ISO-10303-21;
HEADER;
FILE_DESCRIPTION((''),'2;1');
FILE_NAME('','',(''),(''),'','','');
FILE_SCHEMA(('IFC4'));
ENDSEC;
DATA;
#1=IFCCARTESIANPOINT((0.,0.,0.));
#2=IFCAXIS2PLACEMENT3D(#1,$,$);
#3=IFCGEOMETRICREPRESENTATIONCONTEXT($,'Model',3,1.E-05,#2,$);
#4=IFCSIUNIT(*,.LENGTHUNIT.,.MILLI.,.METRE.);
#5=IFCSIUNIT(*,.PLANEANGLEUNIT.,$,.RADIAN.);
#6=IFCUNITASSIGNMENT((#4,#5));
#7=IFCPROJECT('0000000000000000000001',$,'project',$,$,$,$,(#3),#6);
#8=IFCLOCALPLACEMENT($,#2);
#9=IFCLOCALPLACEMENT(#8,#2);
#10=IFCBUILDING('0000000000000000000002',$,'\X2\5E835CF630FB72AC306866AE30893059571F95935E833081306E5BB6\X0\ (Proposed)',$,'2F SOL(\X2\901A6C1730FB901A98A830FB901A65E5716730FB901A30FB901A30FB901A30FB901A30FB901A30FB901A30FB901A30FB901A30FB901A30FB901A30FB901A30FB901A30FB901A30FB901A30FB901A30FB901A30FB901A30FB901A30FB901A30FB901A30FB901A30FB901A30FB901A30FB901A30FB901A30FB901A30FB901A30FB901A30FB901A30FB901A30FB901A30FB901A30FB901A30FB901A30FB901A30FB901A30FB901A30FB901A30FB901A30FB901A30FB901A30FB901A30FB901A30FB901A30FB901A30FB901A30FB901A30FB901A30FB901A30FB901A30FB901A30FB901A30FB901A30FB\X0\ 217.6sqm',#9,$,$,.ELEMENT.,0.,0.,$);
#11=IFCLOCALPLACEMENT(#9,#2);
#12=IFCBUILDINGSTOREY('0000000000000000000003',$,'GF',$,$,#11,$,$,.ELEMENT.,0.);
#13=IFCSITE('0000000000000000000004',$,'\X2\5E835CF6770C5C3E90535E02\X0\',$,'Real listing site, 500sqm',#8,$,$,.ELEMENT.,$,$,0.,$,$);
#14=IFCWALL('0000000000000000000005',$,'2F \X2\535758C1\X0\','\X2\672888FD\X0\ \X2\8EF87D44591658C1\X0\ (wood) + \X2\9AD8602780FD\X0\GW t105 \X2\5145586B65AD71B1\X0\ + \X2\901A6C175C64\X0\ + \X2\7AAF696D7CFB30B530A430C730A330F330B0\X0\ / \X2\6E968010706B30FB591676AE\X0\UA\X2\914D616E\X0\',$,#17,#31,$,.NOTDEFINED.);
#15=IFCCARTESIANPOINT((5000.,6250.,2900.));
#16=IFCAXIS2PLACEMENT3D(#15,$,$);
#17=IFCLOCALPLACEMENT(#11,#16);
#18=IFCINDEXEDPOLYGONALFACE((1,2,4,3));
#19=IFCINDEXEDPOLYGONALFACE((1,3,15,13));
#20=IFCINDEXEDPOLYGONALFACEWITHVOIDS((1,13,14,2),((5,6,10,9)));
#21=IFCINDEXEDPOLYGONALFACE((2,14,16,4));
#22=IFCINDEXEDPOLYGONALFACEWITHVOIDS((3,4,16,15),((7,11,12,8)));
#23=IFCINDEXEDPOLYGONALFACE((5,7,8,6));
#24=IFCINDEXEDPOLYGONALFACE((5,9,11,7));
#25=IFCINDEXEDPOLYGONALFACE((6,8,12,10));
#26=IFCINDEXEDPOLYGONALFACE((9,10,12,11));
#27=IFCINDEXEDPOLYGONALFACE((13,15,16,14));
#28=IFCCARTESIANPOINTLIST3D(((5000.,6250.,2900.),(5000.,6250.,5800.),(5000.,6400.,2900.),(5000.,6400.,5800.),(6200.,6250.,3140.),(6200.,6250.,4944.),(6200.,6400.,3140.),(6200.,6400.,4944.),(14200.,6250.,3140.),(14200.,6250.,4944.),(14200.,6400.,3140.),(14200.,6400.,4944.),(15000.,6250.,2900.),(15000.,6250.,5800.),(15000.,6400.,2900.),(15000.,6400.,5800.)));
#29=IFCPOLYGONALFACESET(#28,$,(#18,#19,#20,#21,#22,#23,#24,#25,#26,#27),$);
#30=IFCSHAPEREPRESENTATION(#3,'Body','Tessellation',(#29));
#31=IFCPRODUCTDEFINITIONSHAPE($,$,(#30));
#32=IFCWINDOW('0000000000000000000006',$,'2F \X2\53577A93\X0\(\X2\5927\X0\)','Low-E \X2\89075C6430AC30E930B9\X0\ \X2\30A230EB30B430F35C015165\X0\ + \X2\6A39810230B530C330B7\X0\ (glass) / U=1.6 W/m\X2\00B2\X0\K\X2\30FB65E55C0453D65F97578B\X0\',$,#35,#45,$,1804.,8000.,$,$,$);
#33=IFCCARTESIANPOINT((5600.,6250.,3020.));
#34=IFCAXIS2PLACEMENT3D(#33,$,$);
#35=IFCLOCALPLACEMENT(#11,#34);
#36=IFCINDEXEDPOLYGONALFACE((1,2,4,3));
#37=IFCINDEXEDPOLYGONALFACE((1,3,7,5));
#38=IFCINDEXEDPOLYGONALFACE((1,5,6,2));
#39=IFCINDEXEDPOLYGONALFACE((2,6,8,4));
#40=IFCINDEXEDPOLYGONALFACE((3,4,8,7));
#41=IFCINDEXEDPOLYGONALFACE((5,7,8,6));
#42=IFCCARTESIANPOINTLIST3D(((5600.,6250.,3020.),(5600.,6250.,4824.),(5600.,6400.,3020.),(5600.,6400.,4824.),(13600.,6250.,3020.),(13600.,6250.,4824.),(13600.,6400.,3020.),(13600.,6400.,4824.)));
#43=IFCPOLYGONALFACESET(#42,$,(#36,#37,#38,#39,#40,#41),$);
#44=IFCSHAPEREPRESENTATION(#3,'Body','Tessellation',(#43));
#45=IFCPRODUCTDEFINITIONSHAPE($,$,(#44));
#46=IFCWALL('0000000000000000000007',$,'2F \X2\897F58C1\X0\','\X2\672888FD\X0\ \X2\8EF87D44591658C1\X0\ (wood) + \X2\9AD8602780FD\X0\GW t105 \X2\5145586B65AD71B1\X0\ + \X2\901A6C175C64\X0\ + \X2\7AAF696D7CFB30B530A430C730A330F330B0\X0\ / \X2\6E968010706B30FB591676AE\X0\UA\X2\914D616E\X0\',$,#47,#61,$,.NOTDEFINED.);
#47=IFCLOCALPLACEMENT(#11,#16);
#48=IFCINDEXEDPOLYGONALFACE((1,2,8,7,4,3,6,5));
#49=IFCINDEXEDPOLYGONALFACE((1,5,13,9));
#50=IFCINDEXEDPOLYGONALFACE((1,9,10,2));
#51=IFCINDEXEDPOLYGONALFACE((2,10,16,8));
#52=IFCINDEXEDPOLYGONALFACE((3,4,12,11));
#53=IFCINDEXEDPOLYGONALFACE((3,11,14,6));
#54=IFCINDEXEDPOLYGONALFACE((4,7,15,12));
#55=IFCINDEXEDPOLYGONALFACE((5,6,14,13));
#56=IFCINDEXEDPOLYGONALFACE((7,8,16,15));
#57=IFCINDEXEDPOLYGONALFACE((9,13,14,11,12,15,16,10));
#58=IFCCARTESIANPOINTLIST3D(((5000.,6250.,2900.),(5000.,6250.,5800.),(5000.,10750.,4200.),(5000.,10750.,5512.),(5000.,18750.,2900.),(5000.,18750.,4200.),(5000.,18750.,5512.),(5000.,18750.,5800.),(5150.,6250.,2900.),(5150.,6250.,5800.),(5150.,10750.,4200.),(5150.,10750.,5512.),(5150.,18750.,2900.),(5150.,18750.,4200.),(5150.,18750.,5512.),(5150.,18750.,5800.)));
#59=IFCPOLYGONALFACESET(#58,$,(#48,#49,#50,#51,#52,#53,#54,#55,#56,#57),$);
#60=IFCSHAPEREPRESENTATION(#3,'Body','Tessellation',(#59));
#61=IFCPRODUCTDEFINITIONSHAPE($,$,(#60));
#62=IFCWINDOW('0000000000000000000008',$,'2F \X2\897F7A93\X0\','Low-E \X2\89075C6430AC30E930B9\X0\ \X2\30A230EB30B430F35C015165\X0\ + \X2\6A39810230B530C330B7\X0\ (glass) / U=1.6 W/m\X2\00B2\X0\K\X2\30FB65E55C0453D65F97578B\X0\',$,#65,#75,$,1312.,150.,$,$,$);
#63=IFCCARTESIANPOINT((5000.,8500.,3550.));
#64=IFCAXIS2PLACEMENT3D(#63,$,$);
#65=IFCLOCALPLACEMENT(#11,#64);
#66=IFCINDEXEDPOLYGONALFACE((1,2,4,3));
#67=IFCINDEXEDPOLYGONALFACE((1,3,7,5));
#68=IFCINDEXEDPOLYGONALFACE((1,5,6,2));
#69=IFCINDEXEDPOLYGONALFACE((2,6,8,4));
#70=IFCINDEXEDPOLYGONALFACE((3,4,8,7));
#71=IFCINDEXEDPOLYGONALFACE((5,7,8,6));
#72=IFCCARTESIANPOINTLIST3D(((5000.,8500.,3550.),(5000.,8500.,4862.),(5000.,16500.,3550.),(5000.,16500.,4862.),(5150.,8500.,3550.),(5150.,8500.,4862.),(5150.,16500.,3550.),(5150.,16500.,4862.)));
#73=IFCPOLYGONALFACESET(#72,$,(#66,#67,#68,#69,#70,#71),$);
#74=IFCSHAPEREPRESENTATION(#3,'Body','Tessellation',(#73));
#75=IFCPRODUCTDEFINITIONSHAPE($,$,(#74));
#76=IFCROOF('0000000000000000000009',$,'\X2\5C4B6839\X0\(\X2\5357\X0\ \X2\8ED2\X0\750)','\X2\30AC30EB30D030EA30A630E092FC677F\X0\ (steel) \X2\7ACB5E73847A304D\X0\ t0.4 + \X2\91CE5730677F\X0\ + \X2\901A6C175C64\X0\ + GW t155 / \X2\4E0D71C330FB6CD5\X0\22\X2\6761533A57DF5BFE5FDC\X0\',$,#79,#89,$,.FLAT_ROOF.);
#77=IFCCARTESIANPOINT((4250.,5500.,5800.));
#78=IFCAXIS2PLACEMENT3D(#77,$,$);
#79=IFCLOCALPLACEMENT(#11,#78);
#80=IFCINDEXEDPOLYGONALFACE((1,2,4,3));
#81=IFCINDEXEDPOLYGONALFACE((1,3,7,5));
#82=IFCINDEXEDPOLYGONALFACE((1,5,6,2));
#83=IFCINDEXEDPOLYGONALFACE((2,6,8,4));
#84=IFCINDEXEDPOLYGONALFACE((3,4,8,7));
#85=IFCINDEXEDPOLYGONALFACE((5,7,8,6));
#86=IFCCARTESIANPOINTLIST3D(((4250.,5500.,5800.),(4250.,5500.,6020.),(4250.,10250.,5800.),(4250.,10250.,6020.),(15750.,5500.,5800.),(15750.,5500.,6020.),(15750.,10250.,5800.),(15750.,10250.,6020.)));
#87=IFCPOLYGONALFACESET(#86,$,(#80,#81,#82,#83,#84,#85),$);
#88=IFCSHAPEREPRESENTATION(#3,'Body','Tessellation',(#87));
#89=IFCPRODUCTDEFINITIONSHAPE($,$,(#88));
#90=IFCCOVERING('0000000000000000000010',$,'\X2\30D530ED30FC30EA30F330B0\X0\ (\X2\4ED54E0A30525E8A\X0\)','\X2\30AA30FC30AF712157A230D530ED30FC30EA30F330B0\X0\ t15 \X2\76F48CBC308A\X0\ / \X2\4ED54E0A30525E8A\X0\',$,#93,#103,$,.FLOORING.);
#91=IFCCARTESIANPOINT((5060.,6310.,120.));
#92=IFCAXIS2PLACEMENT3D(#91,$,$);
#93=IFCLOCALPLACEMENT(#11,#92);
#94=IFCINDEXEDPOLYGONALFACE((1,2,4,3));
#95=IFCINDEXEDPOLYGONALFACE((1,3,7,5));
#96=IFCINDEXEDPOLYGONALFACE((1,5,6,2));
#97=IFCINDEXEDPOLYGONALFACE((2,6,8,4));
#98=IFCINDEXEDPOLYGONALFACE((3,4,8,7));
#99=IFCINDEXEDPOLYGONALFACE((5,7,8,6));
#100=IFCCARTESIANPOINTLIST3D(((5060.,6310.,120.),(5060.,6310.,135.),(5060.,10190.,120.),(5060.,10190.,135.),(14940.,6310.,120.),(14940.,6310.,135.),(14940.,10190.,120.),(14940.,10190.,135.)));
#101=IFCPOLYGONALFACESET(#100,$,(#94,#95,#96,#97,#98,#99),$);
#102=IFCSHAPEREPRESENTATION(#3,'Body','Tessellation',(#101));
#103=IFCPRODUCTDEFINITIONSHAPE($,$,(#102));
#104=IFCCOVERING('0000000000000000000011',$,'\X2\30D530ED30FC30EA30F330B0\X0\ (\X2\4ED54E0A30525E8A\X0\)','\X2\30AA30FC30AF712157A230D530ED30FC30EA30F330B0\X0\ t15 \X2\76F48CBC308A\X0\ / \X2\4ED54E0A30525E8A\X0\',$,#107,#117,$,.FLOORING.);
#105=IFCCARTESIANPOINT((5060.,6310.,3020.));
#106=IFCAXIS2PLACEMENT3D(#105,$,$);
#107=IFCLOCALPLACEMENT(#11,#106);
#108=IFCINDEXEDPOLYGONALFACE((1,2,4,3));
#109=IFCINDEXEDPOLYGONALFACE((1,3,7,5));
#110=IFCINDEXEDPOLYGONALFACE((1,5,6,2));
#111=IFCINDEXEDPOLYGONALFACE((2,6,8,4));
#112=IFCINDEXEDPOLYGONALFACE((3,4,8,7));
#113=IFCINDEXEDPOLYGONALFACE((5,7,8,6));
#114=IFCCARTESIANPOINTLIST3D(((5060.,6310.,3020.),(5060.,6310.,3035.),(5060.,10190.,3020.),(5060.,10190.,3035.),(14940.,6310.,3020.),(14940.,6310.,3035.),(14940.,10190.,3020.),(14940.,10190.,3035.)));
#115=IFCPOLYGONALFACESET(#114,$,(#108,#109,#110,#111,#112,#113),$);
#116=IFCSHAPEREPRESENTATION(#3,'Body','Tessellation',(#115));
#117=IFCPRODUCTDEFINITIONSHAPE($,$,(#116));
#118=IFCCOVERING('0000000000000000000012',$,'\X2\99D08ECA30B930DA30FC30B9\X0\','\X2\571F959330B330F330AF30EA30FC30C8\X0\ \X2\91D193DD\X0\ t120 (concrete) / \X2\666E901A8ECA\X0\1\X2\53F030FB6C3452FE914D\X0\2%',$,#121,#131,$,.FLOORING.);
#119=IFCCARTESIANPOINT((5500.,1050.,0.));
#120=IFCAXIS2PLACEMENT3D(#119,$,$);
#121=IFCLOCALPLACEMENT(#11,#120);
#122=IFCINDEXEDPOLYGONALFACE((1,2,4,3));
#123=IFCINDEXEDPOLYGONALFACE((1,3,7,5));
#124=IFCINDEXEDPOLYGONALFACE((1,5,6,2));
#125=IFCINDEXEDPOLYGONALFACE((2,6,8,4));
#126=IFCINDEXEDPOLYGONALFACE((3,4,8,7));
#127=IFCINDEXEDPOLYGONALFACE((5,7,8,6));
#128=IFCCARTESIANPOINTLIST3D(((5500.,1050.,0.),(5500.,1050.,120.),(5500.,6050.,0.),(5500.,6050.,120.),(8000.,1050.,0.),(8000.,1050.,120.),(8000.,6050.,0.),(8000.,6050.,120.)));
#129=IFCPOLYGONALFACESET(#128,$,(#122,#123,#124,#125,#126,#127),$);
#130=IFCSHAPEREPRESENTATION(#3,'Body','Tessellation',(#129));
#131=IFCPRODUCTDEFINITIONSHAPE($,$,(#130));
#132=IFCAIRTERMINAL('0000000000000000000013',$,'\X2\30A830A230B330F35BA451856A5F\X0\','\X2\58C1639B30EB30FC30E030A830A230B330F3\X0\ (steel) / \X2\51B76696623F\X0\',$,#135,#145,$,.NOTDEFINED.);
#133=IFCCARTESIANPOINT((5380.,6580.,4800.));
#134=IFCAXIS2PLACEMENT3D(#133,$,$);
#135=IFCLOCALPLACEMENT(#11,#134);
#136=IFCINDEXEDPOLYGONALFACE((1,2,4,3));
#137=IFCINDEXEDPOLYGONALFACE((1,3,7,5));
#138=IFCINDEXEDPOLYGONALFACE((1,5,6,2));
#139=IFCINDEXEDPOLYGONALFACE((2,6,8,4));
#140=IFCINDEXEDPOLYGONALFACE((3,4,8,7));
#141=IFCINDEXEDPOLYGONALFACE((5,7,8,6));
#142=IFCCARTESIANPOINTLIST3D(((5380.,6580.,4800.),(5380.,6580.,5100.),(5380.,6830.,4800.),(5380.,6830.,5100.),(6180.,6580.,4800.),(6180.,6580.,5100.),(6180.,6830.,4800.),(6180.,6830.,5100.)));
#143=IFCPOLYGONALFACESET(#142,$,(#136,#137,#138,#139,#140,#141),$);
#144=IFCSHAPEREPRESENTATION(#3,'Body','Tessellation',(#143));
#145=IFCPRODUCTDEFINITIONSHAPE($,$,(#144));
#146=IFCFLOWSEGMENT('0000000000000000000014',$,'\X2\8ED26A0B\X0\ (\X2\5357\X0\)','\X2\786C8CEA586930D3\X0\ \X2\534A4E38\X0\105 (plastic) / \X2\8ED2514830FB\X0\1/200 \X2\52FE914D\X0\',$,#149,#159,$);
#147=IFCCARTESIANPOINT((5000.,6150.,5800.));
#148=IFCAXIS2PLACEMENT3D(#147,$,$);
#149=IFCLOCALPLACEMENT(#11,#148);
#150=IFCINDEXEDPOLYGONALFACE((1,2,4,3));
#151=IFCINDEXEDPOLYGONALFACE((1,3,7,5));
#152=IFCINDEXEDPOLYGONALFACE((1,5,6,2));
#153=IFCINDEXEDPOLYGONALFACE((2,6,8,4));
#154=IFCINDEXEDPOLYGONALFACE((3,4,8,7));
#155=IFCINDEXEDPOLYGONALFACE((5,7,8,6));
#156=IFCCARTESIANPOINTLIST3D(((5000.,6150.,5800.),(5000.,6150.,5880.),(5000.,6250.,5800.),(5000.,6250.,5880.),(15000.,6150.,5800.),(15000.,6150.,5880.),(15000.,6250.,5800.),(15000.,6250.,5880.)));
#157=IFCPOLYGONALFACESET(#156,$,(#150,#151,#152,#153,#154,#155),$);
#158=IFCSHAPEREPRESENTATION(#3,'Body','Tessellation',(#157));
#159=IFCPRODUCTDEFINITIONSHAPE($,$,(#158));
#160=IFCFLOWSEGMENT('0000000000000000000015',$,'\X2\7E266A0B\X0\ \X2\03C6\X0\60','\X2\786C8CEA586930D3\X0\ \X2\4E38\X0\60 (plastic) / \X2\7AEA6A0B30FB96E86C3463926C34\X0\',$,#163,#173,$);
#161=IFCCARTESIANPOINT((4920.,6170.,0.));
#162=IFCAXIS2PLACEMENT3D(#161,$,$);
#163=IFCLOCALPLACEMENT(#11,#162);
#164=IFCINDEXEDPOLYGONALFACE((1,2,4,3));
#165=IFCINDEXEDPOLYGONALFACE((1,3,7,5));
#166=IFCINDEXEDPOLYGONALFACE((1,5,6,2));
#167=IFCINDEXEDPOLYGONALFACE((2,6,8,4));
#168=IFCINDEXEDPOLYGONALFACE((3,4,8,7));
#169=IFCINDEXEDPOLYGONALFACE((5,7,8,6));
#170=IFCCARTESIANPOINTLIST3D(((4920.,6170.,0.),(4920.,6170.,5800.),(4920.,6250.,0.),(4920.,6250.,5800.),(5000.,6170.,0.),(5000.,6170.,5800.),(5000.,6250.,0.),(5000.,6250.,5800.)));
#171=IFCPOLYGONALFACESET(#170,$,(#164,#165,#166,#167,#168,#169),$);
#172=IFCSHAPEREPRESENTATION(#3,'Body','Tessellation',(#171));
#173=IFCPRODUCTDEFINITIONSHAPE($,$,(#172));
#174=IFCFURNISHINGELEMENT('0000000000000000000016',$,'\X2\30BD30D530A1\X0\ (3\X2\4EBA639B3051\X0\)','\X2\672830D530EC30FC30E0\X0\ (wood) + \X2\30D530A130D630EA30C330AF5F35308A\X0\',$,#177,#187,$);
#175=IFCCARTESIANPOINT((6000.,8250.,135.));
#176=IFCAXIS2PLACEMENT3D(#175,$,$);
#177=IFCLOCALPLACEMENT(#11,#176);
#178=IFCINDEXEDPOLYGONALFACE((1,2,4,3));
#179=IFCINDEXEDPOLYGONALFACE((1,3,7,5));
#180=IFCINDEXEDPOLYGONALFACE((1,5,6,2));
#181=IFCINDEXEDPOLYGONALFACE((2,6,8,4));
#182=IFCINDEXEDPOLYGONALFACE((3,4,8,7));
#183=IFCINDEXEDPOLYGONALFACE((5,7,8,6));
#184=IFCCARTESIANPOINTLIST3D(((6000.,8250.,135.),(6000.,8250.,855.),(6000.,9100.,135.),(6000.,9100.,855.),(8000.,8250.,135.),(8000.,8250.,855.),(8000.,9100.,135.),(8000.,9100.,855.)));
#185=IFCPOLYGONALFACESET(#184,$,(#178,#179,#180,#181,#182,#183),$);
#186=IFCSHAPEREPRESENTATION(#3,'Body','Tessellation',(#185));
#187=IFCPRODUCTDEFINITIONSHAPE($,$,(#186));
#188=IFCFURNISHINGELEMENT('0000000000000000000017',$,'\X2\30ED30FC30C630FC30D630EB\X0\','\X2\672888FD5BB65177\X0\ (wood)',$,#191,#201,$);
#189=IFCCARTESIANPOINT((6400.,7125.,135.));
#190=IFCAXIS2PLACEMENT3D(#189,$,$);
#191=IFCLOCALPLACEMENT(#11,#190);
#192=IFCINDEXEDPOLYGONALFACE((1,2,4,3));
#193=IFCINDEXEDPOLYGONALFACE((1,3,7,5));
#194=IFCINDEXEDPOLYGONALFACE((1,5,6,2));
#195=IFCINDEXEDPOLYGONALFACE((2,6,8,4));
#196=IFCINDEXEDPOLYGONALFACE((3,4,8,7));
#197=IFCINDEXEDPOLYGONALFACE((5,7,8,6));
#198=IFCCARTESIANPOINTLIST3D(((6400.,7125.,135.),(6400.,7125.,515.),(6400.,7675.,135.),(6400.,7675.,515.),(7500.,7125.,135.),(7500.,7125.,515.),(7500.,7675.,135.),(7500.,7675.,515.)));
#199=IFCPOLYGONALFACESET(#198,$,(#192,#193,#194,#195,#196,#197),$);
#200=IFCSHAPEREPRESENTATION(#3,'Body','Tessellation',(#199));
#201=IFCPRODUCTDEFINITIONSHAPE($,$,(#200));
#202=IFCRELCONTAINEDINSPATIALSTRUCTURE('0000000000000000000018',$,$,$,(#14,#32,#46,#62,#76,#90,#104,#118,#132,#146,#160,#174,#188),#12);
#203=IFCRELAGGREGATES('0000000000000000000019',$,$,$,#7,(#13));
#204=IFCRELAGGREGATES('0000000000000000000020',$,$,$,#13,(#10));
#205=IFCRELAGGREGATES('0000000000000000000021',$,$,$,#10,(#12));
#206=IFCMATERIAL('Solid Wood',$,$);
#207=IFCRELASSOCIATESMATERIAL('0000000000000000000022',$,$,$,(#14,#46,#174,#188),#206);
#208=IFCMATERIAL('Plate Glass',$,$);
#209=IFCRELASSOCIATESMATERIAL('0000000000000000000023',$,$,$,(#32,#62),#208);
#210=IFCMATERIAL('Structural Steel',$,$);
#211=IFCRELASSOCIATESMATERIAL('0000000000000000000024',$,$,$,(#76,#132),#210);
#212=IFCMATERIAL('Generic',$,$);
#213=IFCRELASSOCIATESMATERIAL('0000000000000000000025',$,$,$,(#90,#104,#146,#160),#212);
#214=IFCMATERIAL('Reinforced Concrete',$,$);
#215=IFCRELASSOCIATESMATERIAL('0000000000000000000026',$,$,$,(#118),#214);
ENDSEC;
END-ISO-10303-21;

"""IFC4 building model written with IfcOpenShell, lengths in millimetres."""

from ifc_helpers import new_model, si_unit, frame, frame_2d, origin, place, context, project, spatial, rectangle, extrude, material, element, fill, save


model = new_model("IFC4")

# Units and contexts
model_context = context("Model", 3, precision=1e-05, world=origin())
ifc_project = project(units=[si_unit("LENGTHUNIT", "METRE", prefix="MILLI"), si_unit("PLANEANGLEUNIT", "RADIAN")], contexts=[model_context])

# Site, building, storey
site_placement = place(None, origin())
site = spatial("IfcSite", under=ifc_project, at=site_placement, Name="広島県尾道市", ObjectType="Real listing site, 500sqm", CompositionType="ELEMENT", RefElevation=0.0)
building_placement = place(site_placement, origin())
building = spatial("IfcBuilding", under=site, at=building_placement, Name="広島・犬と暮らす土間広めの家 (Proposed)", ObjectType="2F SOL(通気・通風・通日照・通・通・通・通・通・通・通・通・通・通・通・通・通・通・通・通・通・通・通・通・通・通・通・通・通・通・通・通・通・通・通・通・通・通・通・通・通・通・通・通・通・通・通・通・通・通・通・通・通・通・通・通・通・ 217.6sqm", CompositionType="ELEMENT", ElevationOfRefHeight=0.0, ElevationOfTerrain=0.0)
storey_placement = place(building_placement, origin())
storey = spatial("IfcBuildingStorey", under=building, at=storey_placement, Name="GF", CompositionType="ELEMENT", Elevation=0.0)

# Shared definitions
ifc_material_1 = material(Name="Solid Wood")

# Shared definitions
ifc_material_2 = material(Name="Reinforced Concrete")

# Shared definitions
ifc_material_3 = material(Name="Plate Glass")

# Walls, openings, windows
wall_1_placement = place(storey_placement, frame((5000.0, 6250.0, 2900.0)))
wall_1 = element("IfcWall", 1, at=wall_1_placement, inside=storey, material=ifc_material_1, Name="2F 南壁", Description="木製 軸組外壁 (wood) + 高性能GW t105 充填断熱 + 通気層 + 窯業系サイディング / 準耐火・外皮UA配慮", PredefinedType="NOTDEFINED", context=model_context, shape_type="SweptSolid", body=[
    extrude(rectangle(XDim=10000.0, YDim=150.0, at=frame_2d((5000.0, 75.0))), frame((5000.0, 6250.0, 2900.0)), (0.0, 0.0, 1.0), 2900.0),
])
opening_1_placement = place(storey_placement, frame((5600.0, 6250.0, 3020.0)))
opening_1 = element("IfcOpeningElement", 2, at=opening_1_placement, cuts=wall_1, PredefinedType="NOTDEFINED", context=model_context, shape_type="SweptSolid", body=[
    extrude(rectangle(XDim=8000.0, YDim=150.0, at=frame_2d((4000.0, 75.0))), frame((5600.0, 6250.0, 3020.0)), (0.0, 0.0, 1.0), 1804.0),
])
window_1_placement = place(storey_placement, frame((5600.0, 6250.0, 3020.0)))
window_1 = element("IfcWindow", 3, at=window_1_placement, inside=storey, material=ifc_material_3, Name="2F 南窓(大)", Description="Low-E 複層ガラス アルゴン封入 + 樹脂サッシ (glass) / U=1.6 W/m²K・日射取得型", OverallHeight=1804.0, OverallWidth=8000.0, context=model_context, shape_type="SweptSolid", body=[
    extrude(rectangle(XDim=8000.0, YDim=150.0, at=frame_2d((4000.0, 75.0))), frame((5600.0, 6250.0, 3020.0)), (0.0, 0.0, 1.0), 1804.0),
])
fill(opening_1, window_1)
wall_2_placement = place(storey_placement, frame((5000.0, 6250.0, 2900.0)))
wall_2 = element("IfcWall", 4, at=wall_2_placement, inside=storey, material=ifc_material_1, Name="2F 西壁", Description="木製 軸組外壁 (wood) + 高性能GW t105 充填断熱 + 通気層 + 窯業系サイディング / 準耐火・外皮UA配慮", PredefinedType="NOTDEFINED", context=model_context, shape_type="SweptSolid", body=[
    extrude(rectangle(XDim=150.0, YDim=12500.0, at=frame_2d((75.0, 6250.0))), frame((5000.0, 6250.0, 2900.0)), (0.0, 0.0, 1.0), 2900.0),
])
opening_2_placement = place(storey_placement, frame((5000.0, 8500.0, 3550.0)))
opening_2 = element("IfcOpeningElement", 5, at=opening_2_placement, cuts=wall_2, PredefinedType="NOTDEFINED", context=model_context, shape_type="SweptSolid", body=[
    extrude(rectangle(XDim=150.0, YDim=8000.0, at=frame_2d((75.0, 4000.0))), frame((5000.0, 8500.0, 3550.0)), (0.0, 0.0, 1.0), 1312.0),
])
window_2_placement = place(storey_placement, frame((5000.0, 8500.0, 3550.0)))
window_2 = element("IfcWindow", 6, at=window_2_placement, inside=storey, material=ifc_material_3, Name="2F 西窓", Description="Low-E 複層ガラス アルゴン封入 + 樹脂サッシ (glass) / U=1.6 W/m²K・日射取得型", OverallHeight=1312.0, OverallWidth=150.0, context=model_context, shape_type="SweptSolid", body=[
    extrude(rectangle(XDim=150.0, YDim=8000.0, at=frame_2d((75.0, 4000.0))), frame((5000.0, 8500.0, 3550.0)), (0.0, 0.0, 1.0), 1312.0),
])
fill(opening_2, window_2)

# Roof
ifc_material_4 = material(Name="Structural Steel")
for number, where, name in (
    (7, (4250.0, 5500.0, 5800.0), "屋根(南 軒750)"),
):
    element("IfcRoof", number, at=place(storey_placement, frame(where)), inside=storey, material=ifc_material_4, Name=name, Description="ガルバリウム鋼板 (steel) 立平葺き t0.4 + 野地板 + 通気層 + GW t155 / 不燃・法22条区域対応", PredefinedType="FLAT_ROOF", context=model_context, shape_type="SweptSolid", body=[
        extrude(rectangle(XDim=11500.0, YDim=4750.0, at=frame_2d((5750.0, 2375.0))), frame((4250.0, 5500.0, 5800.0)), (0.0, 0.0, 1.0), 220.0),
    ])

# Coverings
ifc_material_5 = material(Name="Generic")
covering_1_placement = place(storey_placement, frame((5060.0, 6310.0, 120.0)))
element("IfcCovering", 8, at=covering_1_placement, inside=storey, material=ifc_material_5, Name="フローリング (仕上げ床)", Description="オーク無垢フローリング t15 直貼り / 仕上げ床", PredefinedType="FLOORING", context=model_context, shape_type="SweptSolid", body=[
    extrude(rectangle(XDim=9880.0, YDim=3880.0, at=frame_2d((4940.0, 1940.0))), frame((5060.0, 6310.0, 120.0)), (0.0, 0.0, 1.0), 15.0),
])
covering_2_placement = place(storey_placement, frame((5060.0, 6310.0, 3020.0)))
element("IfcCovering", 9, at=covering_2_placement, inside=storey, material=ifc_material_5, Name="フローリング (仕上げ床)", Description="オーク無垢フローリング t15 直貼り / 仕上げ床", PredefinedType="FLOORING", context=model_context, shape_type="SweptSolid", body=[
    extrude(rectangle(XDim=9880.0, YDim=3880.0, at=frame_2d((4940.0, 1940.0))), frame((5060.0, 6310.0, 3020.0)), (0.0, 0.0, 1.0), 15.0),
])
covering_3_placement = place(storey_placement, frame((5500.0, 1050.0, 0.0)))
element("IfcCovering", 10, at=covering_3_placement, inside=storey, material=ifc_material_2, Name="駐車スペース", Description="土間コンクリート 金鏝 t120 (concrete) / 普通車1台・水勾配2%", PredefinedType="FLOORING", context=model_context, shape_type="SweptSolid", body=[
    extrude(rectangle(XDim=2500.0, YDim=5000.0, at=frame_2d((1250.0, 2500.0))), frame((5500.0, 1050.0, 0.0)), (0.0, 0.0, 1.0), 120.0),
])

# Air terminal
air_terminal_placement = place(storey_placement, frame((5380.0, 6580.0, 4800.0)))
element("IfcAirTerminal", 11, at=air_terminal_placement, inside=storey, material=ifc_material_4, Name="エアコン室内機", Description="壁掛ルームエアコン (steel) / 冷暖房", PredefinedType="NOTDEFINED", context=model_context, shape_type="SweptSolid", body=[
    extrude(rectangle(XDim=800.0, YDim=250.0, at=frame_2d((400.0, 125.0))), frame((5380.0, 6580.0, 4800.0)), (0.0, 0.0, 1.0), 300.0),
])

# Flow segments
flow_segment_1_placement = place(storey_placement, frame((5000.0, 6150.0, 5800.0)))
element("IfcFlowSegment", 12, at=flow_segment_1_placement, inside=storey, material=ifc_material_5, Name="軒樋 (南)", Description="硬質塩ビ 半丸105 (plastic) / 軒先・1/200 勾配", context=model_context, shape_type="SweptSolid", body=[
    extrude(rectangle(XDim=10000.0, YDim=100.0, at=frame_2d((5000.0, 50.0))), frame((5000.0, 6150.0, 5800.0)), (0.0, 0.0, 1.0), 80.0),
])
flow_segment_2_placement = place(storey_placement, frame((4920.0, 6170.0, 0.0)))
element("IfcFlowSegment", 13, at=flow_segment_2_placement, inside=storey, material=ifc_material_5, Name="縦樋 φ60", Description="硬質塩ビ 丸60 (plastic) / 竪樋・雨水排水", context=model_context, shape_type="SweptSolid", body=[
    extrude(rectangle(XDim=80.0, YDim=80.0, at=frame_2d((40.0, 40.0))), frame((4920.0, 6170.0, 0.0)), (0.0, 0.0, 1.0), 5800.0),
])

# Furnishing elements
furnishing_1_placement = place(storey_placement, frame((6000.0, 8250.0, 135.0)))
element("IfcFurnishingElement", 14, at=furnishing_1_placement, inside=storey, material=ifc_material_1, Name="ソファ (3人掛け)", Description="木フレーム (wood) + ファブリック張り", context=model_context, shape_type="SweptSolid", body=[
    extrude(rectangle(XDim=2000.0, YDim=850.0, at=frame_2d((1000.0, 425.0))), frame((6000.0, 8250.0, 135.0)), (0.0, 0.0, 1.0), 720.0),
])
furnishing_2_placement = place(storey_placement, frame((6400.0, 7125.0, 135.0)))
element("IfcFurnishingElement", 15, at=furnishing_2_placement, inside=storey, material=ifc_material_1, Name="ローテーブル", Description="木製家具 (wood)", context=model_context, shape_type="SweptSolid", body=[
    extrude(rectangle(XDim=1100.0, YDim=550.0, at=frame_2d((550.0, 275.0))), frame((6400.0, 7125.0, 135.0)), (0.0, 0.0, 1.0), 380.0),
])

save(model, "model.ifc")
